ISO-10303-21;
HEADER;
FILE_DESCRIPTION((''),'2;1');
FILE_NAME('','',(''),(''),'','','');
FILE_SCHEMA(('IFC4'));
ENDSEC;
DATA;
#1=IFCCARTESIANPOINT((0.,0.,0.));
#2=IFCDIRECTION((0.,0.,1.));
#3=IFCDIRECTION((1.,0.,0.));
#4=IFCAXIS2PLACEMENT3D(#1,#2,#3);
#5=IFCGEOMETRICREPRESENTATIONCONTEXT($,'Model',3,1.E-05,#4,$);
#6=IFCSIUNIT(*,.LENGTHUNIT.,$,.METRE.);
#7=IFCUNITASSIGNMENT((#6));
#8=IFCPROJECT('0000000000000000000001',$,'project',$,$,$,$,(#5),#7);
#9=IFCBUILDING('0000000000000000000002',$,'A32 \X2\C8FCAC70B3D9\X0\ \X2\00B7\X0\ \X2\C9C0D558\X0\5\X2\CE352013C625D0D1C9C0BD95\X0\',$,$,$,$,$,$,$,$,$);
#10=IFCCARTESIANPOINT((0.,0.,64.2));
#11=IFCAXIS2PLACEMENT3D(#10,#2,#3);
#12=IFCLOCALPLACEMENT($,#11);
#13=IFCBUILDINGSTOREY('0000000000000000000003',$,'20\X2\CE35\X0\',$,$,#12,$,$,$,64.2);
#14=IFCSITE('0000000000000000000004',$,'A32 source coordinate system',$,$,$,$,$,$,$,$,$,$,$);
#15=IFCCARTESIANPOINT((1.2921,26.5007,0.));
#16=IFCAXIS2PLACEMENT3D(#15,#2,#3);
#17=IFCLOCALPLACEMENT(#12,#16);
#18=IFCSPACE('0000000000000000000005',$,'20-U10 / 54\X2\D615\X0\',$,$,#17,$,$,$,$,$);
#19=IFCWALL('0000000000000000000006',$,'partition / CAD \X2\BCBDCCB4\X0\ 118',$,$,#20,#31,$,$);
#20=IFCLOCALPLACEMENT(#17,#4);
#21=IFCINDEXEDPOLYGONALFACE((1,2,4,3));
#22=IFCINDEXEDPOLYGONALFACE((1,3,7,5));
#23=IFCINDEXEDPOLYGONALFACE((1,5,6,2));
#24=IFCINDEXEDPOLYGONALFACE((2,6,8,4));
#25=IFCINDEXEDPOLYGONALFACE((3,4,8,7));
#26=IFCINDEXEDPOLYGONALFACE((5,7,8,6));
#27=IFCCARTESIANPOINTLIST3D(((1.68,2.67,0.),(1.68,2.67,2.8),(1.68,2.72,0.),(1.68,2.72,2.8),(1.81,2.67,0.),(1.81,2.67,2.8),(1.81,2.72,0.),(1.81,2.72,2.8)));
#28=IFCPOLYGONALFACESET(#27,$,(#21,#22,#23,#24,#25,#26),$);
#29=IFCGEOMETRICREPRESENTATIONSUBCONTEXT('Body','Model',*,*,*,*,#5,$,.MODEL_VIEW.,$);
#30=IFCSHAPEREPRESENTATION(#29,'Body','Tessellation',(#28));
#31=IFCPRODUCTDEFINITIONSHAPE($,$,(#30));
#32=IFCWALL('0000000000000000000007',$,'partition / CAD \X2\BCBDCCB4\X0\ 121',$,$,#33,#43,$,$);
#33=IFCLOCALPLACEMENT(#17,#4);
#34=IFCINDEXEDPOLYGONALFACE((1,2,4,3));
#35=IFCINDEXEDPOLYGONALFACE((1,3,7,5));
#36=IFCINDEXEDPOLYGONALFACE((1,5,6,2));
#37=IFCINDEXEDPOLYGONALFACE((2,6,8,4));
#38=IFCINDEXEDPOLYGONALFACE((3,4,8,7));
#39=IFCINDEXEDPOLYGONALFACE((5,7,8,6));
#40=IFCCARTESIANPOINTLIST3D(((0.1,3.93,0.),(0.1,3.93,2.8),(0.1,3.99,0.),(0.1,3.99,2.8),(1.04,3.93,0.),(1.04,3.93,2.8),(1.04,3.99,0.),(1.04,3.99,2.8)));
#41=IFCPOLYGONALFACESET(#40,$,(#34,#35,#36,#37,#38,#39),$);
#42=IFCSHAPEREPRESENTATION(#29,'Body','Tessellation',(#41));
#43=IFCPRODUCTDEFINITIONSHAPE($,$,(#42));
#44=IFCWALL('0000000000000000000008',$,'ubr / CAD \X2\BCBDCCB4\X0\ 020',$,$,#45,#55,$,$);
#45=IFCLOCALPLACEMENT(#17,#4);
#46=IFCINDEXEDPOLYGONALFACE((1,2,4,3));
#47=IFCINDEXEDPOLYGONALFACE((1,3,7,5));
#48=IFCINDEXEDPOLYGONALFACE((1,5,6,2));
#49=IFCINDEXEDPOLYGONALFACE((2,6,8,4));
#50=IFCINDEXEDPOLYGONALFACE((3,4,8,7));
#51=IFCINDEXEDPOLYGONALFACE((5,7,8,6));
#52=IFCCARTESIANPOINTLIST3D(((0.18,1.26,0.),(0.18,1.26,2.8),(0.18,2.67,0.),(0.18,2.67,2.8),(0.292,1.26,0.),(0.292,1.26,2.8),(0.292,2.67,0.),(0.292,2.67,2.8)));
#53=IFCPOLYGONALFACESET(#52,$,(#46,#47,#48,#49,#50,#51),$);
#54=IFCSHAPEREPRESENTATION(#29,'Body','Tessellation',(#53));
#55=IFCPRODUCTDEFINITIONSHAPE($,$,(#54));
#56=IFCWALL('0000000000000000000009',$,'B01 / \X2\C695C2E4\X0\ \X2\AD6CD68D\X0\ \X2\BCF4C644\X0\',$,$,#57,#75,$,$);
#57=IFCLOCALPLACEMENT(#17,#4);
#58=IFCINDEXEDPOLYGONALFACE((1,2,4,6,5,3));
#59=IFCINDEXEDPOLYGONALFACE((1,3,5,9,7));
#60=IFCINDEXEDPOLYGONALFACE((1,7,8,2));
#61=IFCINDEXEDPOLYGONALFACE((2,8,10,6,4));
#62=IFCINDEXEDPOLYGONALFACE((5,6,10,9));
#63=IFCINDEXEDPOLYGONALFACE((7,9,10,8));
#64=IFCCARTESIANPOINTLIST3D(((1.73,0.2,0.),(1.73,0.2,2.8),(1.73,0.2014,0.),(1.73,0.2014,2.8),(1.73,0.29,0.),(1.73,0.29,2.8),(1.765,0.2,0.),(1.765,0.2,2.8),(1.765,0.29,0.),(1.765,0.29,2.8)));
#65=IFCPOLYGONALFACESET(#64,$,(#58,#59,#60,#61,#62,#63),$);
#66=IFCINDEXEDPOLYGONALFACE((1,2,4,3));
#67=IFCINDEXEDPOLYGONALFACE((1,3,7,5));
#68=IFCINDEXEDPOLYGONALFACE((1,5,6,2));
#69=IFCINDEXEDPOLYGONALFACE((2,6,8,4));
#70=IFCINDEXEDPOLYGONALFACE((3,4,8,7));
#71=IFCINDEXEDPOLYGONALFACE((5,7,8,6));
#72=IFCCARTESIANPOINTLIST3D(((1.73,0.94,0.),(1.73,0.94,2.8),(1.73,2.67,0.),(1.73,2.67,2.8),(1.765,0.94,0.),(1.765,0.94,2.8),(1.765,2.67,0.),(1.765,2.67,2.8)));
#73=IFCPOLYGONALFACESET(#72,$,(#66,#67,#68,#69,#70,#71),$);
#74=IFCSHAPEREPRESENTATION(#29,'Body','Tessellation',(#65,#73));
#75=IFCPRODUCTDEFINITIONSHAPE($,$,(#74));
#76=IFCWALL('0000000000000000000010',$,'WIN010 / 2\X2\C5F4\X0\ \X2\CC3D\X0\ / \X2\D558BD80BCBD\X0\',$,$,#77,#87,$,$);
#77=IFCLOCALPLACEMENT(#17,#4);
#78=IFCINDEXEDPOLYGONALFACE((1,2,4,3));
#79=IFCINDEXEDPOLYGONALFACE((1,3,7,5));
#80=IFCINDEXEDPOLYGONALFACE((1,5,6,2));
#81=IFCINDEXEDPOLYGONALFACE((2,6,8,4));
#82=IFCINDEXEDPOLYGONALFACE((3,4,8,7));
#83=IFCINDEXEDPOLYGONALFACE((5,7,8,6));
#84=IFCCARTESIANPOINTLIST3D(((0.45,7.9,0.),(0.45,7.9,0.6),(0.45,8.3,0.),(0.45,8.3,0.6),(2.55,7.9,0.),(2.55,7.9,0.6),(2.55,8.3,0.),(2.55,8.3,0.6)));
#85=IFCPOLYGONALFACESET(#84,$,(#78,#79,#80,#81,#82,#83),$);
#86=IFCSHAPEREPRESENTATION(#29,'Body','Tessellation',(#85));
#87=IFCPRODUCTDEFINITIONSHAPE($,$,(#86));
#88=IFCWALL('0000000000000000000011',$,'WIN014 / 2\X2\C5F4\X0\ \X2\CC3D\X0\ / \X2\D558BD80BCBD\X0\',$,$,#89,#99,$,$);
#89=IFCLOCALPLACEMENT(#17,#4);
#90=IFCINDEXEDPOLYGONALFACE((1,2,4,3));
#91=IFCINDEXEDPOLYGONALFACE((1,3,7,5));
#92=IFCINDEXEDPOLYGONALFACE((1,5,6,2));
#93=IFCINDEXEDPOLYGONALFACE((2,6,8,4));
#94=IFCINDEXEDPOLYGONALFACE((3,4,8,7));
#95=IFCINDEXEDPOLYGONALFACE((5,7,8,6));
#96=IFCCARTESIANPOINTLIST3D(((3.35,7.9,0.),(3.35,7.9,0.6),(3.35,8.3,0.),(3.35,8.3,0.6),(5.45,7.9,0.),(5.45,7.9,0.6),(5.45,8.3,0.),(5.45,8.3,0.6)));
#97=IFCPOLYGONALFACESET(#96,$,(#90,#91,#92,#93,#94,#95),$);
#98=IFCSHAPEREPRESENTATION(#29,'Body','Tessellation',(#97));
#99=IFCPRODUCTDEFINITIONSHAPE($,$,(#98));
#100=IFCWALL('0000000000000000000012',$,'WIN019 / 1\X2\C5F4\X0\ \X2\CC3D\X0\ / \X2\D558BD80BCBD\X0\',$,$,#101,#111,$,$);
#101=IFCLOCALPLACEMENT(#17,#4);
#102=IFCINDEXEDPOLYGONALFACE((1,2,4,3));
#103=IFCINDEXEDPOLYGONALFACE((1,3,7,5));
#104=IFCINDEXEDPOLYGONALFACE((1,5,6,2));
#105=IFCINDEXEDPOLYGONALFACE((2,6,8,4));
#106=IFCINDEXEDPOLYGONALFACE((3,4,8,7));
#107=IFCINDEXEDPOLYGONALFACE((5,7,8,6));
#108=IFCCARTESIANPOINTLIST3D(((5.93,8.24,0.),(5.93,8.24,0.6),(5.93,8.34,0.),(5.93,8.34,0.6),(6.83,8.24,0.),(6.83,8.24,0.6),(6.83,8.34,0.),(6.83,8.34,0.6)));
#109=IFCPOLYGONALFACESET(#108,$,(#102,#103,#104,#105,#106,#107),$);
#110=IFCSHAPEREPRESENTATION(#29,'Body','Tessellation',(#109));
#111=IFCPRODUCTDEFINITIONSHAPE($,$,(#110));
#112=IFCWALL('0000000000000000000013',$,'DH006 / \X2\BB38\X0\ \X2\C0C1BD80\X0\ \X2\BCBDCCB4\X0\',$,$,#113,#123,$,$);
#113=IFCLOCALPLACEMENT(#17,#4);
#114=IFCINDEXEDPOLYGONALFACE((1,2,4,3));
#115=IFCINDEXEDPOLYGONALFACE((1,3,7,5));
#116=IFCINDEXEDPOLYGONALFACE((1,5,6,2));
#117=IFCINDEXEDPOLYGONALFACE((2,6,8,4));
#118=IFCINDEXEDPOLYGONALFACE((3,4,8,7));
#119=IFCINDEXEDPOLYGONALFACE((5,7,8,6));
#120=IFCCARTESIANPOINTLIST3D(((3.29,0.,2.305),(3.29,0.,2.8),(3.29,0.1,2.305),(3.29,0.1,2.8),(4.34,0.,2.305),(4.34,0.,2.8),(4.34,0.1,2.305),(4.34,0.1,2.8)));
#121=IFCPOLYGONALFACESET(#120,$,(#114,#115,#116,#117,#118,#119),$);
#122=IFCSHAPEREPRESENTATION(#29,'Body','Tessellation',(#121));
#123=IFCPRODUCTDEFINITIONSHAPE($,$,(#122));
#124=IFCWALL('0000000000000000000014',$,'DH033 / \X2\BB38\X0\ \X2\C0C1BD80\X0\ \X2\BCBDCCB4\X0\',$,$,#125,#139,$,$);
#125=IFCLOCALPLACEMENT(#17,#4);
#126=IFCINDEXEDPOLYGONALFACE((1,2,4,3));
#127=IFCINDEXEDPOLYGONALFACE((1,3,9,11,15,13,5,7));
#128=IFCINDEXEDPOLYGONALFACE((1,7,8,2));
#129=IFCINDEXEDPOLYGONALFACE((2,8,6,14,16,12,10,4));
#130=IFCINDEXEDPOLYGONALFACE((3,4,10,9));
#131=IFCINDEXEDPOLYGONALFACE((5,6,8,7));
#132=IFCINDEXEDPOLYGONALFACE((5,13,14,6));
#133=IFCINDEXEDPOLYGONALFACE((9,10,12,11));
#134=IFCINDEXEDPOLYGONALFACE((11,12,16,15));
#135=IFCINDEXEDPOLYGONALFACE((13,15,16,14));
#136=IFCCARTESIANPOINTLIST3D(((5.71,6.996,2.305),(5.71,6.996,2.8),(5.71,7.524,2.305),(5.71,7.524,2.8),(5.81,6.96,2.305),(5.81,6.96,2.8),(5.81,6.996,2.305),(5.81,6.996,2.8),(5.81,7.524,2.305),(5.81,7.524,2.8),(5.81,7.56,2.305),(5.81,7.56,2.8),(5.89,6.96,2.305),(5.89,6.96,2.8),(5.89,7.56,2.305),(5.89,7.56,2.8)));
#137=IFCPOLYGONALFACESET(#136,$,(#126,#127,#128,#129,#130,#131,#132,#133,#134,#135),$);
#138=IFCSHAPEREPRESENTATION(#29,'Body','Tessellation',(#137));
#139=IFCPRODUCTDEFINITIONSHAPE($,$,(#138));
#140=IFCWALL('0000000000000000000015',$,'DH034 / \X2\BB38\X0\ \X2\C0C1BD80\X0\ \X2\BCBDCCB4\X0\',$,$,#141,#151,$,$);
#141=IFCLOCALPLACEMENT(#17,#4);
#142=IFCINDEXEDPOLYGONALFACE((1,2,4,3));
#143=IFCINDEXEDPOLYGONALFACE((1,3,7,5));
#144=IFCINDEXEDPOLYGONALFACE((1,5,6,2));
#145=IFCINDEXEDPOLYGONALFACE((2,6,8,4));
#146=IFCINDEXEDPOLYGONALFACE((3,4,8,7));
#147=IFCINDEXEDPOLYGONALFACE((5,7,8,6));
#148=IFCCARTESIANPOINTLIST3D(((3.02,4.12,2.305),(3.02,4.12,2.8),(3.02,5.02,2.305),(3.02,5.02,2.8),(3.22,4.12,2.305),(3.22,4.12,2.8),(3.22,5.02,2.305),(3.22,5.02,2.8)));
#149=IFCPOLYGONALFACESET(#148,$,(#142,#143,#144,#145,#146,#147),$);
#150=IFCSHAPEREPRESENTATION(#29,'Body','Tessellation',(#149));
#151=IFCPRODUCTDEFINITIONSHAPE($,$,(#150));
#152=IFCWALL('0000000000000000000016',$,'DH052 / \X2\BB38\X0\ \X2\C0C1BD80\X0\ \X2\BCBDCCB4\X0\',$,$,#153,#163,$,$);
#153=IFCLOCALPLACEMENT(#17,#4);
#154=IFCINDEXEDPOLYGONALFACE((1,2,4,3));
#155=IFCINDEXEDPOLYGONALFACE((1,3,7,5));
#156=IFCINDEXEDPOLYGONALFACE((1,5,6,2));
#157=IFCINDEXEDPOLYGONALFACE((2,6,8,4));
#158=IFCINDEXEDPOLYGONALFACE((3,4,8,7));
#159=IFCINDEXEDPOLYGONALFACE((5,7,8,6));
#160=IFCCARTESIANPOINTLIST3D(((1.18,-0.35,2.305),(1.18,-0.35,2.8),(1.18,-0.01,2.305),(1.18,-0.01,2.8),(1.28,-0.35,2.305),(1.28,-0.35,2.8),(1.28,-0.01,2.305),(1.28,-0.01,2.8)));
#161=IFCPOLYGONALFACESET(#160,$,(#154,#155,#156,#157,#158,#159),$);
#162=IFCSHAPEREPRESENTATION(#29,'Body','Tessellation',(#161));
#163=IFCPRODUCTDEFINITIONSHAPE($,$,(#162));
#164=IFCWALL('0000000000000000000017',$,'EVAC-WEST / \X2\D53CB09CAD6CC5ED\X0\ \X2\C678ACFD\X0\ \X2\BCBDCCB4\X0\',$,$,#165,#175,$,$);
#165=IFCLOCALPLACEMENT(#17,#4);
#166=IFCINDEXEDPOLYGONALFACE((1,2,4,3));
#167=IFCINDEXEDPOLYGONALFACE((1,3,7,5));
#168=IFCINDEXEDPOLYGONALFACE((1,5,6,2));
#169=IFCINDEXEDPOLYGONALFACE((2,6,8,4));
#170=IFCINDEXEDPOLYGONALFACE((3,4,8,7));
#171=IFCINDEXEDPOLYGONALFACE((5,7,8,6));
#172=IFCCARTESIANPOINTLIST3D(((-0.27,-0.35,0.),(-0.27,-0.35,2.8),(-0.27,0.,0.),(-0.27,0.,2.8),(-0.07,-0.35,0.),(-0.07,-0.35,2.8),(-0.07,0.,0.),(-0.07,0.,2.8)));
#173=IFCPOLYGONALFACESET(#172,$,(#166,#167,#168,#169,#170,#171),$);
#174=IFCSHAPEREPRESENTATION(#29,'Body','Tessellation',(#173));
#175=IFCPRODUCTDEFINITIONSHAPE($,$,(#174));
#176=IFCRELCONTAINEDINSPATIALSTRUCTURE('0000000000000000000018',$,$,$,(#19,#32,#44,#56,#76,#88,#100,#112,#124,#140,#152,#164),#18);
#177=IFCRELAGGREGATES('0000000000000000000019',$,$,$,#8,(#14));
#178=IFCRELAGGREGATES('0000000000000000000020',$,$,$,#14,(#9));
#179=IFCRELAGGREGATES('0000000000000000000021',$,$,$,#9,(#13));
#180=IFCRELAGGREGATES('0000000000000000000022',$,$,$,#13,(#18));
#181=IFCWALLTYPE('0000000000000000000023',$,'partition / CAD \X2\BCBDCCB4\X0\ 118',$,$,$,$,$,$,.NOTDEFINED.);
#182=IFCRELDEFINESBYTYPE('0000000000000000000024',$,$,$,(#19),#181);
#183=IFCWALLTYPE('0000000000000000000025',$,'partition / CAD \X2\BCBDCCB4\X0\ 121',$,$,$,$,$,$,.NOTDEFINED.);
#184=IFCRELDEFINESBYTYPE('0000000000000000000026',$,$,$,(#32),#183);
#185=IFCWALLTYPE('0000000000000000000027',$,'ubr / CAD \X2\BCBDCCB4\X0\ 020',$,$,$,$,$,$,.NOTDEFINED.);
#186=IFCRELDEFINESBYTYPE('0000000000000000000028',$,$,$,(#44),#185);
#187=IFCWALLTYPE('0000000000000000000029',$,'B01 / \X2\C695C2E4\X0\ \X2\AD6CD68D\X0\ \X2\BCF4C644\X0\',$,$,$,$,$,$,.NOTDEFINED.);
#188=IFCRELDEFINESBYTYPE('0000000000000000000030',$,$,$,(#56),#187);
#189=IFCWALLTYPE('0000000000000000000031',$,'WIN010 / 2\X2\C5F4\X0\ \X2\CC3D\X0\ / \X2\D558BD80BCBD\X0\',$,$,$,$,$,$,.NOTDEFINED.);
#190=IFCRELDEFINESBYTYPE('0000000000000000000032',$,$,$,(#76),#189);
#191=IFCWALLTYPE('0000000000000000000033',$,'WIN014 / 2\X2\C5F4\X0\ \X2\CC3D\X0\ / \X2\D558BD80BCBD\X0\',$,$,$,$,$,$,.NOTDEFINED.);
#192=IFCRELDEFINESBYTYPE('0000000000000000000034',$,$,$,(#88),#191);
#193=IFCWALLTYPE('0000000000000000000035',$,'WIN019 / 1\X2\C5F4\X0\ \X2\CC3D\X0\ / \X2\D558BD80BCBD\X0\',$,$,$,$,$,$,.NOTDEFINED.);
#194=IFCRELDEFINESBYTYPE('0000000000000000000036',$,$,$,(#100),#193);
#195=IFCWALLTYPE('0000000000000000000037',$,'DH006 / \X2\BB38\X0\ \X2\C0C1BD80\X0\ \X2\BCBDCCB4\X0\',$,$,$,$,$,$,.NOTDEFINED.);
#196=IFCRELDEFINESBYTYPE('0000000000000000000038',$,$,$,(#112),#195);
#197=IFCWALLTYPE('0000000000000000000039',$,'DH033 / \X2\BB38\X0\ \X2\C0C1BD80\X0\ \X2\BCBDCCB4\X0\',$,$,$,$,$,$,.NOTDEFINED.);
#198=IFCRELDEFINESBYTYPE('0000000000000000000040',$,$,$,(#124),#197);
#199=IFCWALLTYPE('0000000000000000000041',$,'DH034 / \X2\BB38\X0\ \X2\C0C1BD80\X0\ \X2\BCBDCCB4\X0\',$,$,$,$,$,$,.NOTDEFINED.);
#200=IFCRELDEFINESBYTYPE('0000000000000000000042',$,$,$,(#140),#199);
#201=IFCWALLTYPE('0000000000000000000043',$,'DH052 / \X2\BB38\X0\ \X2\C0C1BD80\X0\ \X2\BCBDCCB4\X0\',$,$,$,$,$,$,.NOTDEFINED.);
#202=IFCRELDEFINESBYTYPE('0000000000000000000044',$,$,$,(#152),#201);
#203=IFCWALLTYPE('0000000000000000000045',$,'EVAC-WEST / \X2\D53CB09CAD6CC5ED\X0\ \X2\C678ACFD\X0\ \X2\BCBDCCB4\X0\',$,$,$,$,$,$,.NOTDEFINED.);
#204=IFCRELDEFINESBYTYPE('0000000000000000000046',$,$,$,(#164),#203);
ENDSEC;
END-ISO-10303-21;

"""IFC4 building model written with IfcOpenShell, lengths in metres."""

from ifc_helpers import new_model, si_unit, frame, origin, origin_with_axes, place, context, subcontext, project, spatial, polyline, outline, extrude, source, transform, mapped, type_object, type_shapes, element, save


model = new_model("IFC4")

# Units and contexts
model_context = context("Model", 3, precision=1e-05, world=origin_with_axes())
body_context = subcontext(model_context, "Body", "Model", "MODEL_VIEW")
ifc_project = project(units=[si_unit("LENGTHUNIT", "METRE")], contexts=[model_context])

# Site, building, storey, space
site = spatial("IfcSite", under=ifc_project, Name="A32 source coordinate system")
building = spatial("IfcBuilding", under=site, Name="A32 주거동 · 지하5층–옥탑지붕")
storey_placement = place(None, frame((0.0, 0.0, 64.2), z_axis=(0.0, 0.0, 1.0), x_axis=(1.0, 0.0, 0.0)))
storey = spatial("IfcBuildingStorey", under=building, at=storey_placement, Name="20층", Elevation=64.2)
space_placement = place(storey_placement, frame((1.2921, 26.5007, 0.0), z_axis=(0.0, 0.0, 1.0), x_axis=(1.0, 0.0, 0.0)))
space = spatial("IfcSpace", under=storey, at=space_placement, Name="20-U10 / 54형")

# Walls
wall_type_1 = type_object("IfcWallType", Name="partition / CAD 벽체 118", PredefinedType="NOTDEFINED")
shared_shape_1 = source(origin(), body_context, "Body", "SweptSolid", [
    extrude(outline(polyline([(1.81, 2.67), (1.68, 2.67), (1.68, 2.72), (1.81, 2.72), (1.81, 2.67)])), origin(), (0.0, 0.0, 1.0), 2.8),
])
type_shapes(wall_type_1, [shared_shape_1])
wall_1_placement = place(space_placement, origin_with_axes())
element("IfcWall", 1, at=wall_1_placement, inside=space, type_object=wall_type_1, Name="partition / CAD 벽체 118", context=body_context, shape_type="MappedRepresentation", body=[
    mapped(shared_shape_1, transform((0.0, 0.0, 0.0), scale=1.0)),
])
wall_type_2 = type_object("IfcWallType", Name="partition / CAD 벽체 121", PredefinedType="NOTDEFINED")
shared_shape_2 = source(origin(), body_context, "Body", "SweptSolid", [
    extrude(outline(polyline([(0.1, 3.99), (1.04, 3.99), (1.04, 3.93), (0.1, 3.93), (0.1, 3.99)])), origin(), (0.0, 0.0, 1.0), 2.8),
])
type_shapes(wall_type_2, [shared_shape_2])
wall_2_placement = place(space_placement, origin_with_axes())
element("IfcWall", 2, at=wall_2_placement, inside=space, type_object=wall_type_2, Name="partition / CAD 벽체 121", context=body_context, shape_type="MappedRepresentation", body=[
    mapped(shared_shape_2, transform((0.0, 0.0, 0.0), scale=1.0)),
])
wall_type_3 = type_object("IfcWallType", Name="ubr / CAD 벽체 020", PredefinedType="NOTDEFINED")
shared_shape_3 = source(origin(), body_context, "Body", "SweptSolid", [
    extrude(outline(polyline([(0.18, 1.26), (0.18, 2.67), (0.292, 2.67), (0.292, 1.26), (0.18, 1.26)])), origin(), (0.0, 0.0, 1.0), 2.8),
])
type_shapes(wall_type_3, [shared_shape_3])
wall_3_placement = place(space_placement, origin_with_axes())
element("IfcWall", 3, at=wall_3_placement, inside=space, type_object=wall_type_3, Name="ubr / CAD 벽체 020", context=body_context, shape_type="MappedRepresentation", body=[
    mapped(shared_shape_3, transform((0.0, 0.0, 0.0), scale=1.0)),
])
wall_type_4 = type_object("IfcWallType", Name="B01 / 욕실 구획 보완", PredefinedType="NOTDEFINED")
shared_shape_4 = source(origin(), body_context, "Body", "SweptSolid", [
    extrude(outline(polyline([(1.765, 0.2), (1.73, 0.2), (1.73, 0.2014), (1.73, 0.29), (1.765, 0.29), (1.765, 0.2)])), origin(), (0.0, 0.0, 1.0), 2.8),
    extrude(outline(polyline([(1.765, 2.67), (1.765, 0.94), (1.73, 0.94), (1.73, 2.67), (1.765, 2.67)])), origin(), (0.0, 0.0, 1.0), 2.8),
])
type_shapes(wall_type_4, [shared_shape_4])
wall_4_placement = place(space_placement, origin_with_axes())
element("IfcWall", 4, at=wall_4_placement, inside=space, type_object=wall_type_4, Name="B01 / 욕실 구획 보완", context=body_context, shape_type="MappedRepresentation", body=[
    mapped(shared_shape_4, transform((0.0, 0.0, 0.0), scale=1.0)),
])
wall_type_5 = type_object("IfcWallType", Name="WIN010 / 2열 창 / 하부벽", PredefinedType="NOTDEFINED")
shared_shape_5 = source(origin(), body_context, "Body", "SweptSolid", [
    extrude(outline(polyline([(2.55, 8.3), (2.55, 7.9), (0.45, 7.9), (0.45, 8.3), (2.55, 8.3)])), origin(), (0.0, 0.0, 1.0), 0.6),
])
type_shapes(wall_type_5, [shared_shape_5])
wall_5_placement = place(space_placement, origin_with_axes())
element("IfcWall", 5, at=wall_5_placement, inside=space, type_object=wall_type_5, Name="WIN010 / 2열 창 / 하부벽", context=body_context, shape_type="MappedRepresentation", body=[
    mapped(shared_shape_5, transform((0.0, 0.0, 0.0), scale=1.0)),
])
wall_type_6 = type_object("IfcWallType", Name="WIN014 / 2열 창 / 하부벽", PredefinedType="NOTDEFINED")
shared_shape_6 = source(origin(), body_context, "Body", "SweptSolid", [
    extrude(outline(polyline([(5.45, 8.3), (5.45, 7.9), (3.35, 7.9), (3.35, 8.3), (5.45, 8.3)])), origin(), (0.0, 0.0, 1.0), 0.6),
])
type_shapes(wall_type_6, [shared_shape_6])
wall_6_placement = place(space_placement, origin_with_axes())
element("IfcWall", 6, at=wall_6_placement, inside=space, type_object=wall_type_6, Name="WIN014 / 2열 창 / 하부벽", context=body_context, shape_type="MappedRepresentation", body=[
    mapped(shared_shape_6, transform((0.0, 0.0, 0.0), scale=1.0)),
])
wall_type_7 = type_object("IfcWallType", Name="WIN019 / 1열 창 / 하부벽", PredefinedType="NOTDEFINED")
shared_shape_7 = source(origin(), body_context, "Body", "SweptSolid", [
    extrude(outline(polyline([(6.83, 8.34), (6.83, 8.24), (5.93, 8.24), (5.93, 8.34), (6.83, 8.34)])), origin(), (0.0, 0.0, 1.0), 0.6),
])
type_shapes(wall_type_7, [shared_shape_7])
wall_7_placement = place(space_placement, origin_with_axes())
element("IfcWall", 7, at=wall_7_placement, inside=space, type_object=wall_type_7, Name="WIN019 / 1열 창 / 하부벽", context=body_context, shape_type="MappedRepresentation", body=[
    mapped(shared_shape_7, transform((0.0, 0.0, 0.0), scale=1.0)),
])
wall_type_8 = type_object("IfcWallType", Name="DH006 / 문 상부 벽체", PredefinedType="NOTDEFINED")
shared_shape_8 = source(origin(), body_context, "Body", "SweptSolid", [
    extrude(outline(polyline([(4.34, 0.0), (3.29, 0.0), (3.29, 0.1), (4.34, 0.1), (4.34, 0.0)])), frame((0.0, 0.0, 2.305)), (0.0, 0.0, 1.0), 0.495),
])
type_shapes(wall_type_8, [shared_shape_8])
wall_8_placement = place(space_placement, origin_with_axes())
element("IfcWall", 8, at=wall_8_placement, inside=space, type_object=wall_type_8, Name="DH006 / 문 상부 벽체", context=body_context, shape_type="MappedRepresentation", body=[
    mapped(shared_shape_8, transform((0.0, 0.0, 0.0), scale=1.0)),
])
wall_type_9 = type_object("IfcWallType", Name="DH033 / 문 상부 벽체", PredefinedType="NOTDEFINED")
shared_shape_9 = source(origin(), body_context, "Body", "SweptSolid", [
    extrude(outline(polyline([(5.81, 6.996), (5.71, 6.996), (5.71, 7.524), (5.81, 7.524), (5.81, 7.56), (5.89, 7.56), (5.89, 6.96), (5.81, 6.96), (5.81, 6.996)])), frame((0.0, 0.0, 2.305)), (0.0, 0.0, 1.0), 0.495),
])
type_shapes(wall_type_9, [shared_shape_9])
wall_9_placement = place(space_placement, origin_with_axes())
element("IfcWall", 9, at=wall_9_placement, inside=space, type_object=wall_type_9, Name="DH033 / 문 상부 벽체", context=body_context, shape_type="MappedRepresentation", body=[
    mapped(shared_shape_9, transform((0.0, 0.0, 0.0), scale=1.0)),
])
wall_type_10 = type_object("IfcWallType", Name="DH034 / 문 상부 벽체", PredefinedType="NOTDEFINED")
shared_shape_10 = source(origin(), body_context, "Body", "SweptSolid", [
    extrude(outline(polyline([(3.22, 4.12), (3.02, 4.12), (3.02, 5.02), (3.22, 5.02), (3.22, 4.12)])), frame((0.0, 0.0, 2.305)), (0.0, 0.0, 1.0), 0.495),
])
type_shapes(wall_type_10, [shared_shape_10])
wall_10_placement = place(space_placement, origin_with_axes())
element("IfcWall", 10, at=wall_10_placement, inside=space, type_object=wall_type_10, Name="DH034 / 문 상부 벽체", context=body_context, shape_type="MappedRepresentation", body=[
    mapped(shared_shape_10, transform((0.0, 0.0, 0.0), scale=1.0)),
])
wall_type_11 = type_object("IfcWallType", Name="DH052 / 문 상부 벽체", PredefinedType="NOTDEFINED")
shared_shape_11 = source(origin(), body_context, "Body", "SweptSolid", [
    extrude(outline(polyline([(1.28, -0.35), (1.18, -0.35), (1.18, -0.01), (1.28, -0.01), (1.28, -0.35)])), frame((0.0, 0.0, 2.305)), (0.0, 0.0, 1.0), 0.495),
])
type_shapes(wall_type_11, [shared_shape_11])
wall_11_placement = place(space_placement, origin_with_axes())
element("IfcWall", 11, at=wall_11_placement, inside=space, type_object=wall_type_11, Name="DH052 / 문 상부 벽체", context=body_context, shape_type="MappedRepresentation", body=[
    mapped(shared_shape_11, transform((0.0, 0.0, 0.0), scale=1.0)),
])
wall_type_12 = type_object("IfcWallType", Name="EVAC-WEST / 피난구역 외곽 벽체", PredefinedType="NOTDEFINED")
shared_shape_12 = source(origin(), body_context, "Body", "SweptSolid", [
    extrude(outline(polyline([(-0.07, 0.0), (-0.07, -0.35), (-0.27, -0.35), (-0.27, 0.0), (-0.07, 0.0)])), origin(), (0.0, 0.0, 1.0), 2.8),
])
type_shapes(wall_type_12, [shared_shape_12])
wall_12_placement = place(space_placement, origin_with_axes())
element("IfcWall", 12, at=wall_12_placement, inside=space, type_object=wall_type_12, Name="EVAC-WEST / 피난구역 외곽 벽체", context=body_context, shape_type="MappedRepresentation", body=[
    mapped(shared_shape_12, transform((0.0, 0.0, 0.0), scale=1.0)),
])

save(model, "model.ifc")
